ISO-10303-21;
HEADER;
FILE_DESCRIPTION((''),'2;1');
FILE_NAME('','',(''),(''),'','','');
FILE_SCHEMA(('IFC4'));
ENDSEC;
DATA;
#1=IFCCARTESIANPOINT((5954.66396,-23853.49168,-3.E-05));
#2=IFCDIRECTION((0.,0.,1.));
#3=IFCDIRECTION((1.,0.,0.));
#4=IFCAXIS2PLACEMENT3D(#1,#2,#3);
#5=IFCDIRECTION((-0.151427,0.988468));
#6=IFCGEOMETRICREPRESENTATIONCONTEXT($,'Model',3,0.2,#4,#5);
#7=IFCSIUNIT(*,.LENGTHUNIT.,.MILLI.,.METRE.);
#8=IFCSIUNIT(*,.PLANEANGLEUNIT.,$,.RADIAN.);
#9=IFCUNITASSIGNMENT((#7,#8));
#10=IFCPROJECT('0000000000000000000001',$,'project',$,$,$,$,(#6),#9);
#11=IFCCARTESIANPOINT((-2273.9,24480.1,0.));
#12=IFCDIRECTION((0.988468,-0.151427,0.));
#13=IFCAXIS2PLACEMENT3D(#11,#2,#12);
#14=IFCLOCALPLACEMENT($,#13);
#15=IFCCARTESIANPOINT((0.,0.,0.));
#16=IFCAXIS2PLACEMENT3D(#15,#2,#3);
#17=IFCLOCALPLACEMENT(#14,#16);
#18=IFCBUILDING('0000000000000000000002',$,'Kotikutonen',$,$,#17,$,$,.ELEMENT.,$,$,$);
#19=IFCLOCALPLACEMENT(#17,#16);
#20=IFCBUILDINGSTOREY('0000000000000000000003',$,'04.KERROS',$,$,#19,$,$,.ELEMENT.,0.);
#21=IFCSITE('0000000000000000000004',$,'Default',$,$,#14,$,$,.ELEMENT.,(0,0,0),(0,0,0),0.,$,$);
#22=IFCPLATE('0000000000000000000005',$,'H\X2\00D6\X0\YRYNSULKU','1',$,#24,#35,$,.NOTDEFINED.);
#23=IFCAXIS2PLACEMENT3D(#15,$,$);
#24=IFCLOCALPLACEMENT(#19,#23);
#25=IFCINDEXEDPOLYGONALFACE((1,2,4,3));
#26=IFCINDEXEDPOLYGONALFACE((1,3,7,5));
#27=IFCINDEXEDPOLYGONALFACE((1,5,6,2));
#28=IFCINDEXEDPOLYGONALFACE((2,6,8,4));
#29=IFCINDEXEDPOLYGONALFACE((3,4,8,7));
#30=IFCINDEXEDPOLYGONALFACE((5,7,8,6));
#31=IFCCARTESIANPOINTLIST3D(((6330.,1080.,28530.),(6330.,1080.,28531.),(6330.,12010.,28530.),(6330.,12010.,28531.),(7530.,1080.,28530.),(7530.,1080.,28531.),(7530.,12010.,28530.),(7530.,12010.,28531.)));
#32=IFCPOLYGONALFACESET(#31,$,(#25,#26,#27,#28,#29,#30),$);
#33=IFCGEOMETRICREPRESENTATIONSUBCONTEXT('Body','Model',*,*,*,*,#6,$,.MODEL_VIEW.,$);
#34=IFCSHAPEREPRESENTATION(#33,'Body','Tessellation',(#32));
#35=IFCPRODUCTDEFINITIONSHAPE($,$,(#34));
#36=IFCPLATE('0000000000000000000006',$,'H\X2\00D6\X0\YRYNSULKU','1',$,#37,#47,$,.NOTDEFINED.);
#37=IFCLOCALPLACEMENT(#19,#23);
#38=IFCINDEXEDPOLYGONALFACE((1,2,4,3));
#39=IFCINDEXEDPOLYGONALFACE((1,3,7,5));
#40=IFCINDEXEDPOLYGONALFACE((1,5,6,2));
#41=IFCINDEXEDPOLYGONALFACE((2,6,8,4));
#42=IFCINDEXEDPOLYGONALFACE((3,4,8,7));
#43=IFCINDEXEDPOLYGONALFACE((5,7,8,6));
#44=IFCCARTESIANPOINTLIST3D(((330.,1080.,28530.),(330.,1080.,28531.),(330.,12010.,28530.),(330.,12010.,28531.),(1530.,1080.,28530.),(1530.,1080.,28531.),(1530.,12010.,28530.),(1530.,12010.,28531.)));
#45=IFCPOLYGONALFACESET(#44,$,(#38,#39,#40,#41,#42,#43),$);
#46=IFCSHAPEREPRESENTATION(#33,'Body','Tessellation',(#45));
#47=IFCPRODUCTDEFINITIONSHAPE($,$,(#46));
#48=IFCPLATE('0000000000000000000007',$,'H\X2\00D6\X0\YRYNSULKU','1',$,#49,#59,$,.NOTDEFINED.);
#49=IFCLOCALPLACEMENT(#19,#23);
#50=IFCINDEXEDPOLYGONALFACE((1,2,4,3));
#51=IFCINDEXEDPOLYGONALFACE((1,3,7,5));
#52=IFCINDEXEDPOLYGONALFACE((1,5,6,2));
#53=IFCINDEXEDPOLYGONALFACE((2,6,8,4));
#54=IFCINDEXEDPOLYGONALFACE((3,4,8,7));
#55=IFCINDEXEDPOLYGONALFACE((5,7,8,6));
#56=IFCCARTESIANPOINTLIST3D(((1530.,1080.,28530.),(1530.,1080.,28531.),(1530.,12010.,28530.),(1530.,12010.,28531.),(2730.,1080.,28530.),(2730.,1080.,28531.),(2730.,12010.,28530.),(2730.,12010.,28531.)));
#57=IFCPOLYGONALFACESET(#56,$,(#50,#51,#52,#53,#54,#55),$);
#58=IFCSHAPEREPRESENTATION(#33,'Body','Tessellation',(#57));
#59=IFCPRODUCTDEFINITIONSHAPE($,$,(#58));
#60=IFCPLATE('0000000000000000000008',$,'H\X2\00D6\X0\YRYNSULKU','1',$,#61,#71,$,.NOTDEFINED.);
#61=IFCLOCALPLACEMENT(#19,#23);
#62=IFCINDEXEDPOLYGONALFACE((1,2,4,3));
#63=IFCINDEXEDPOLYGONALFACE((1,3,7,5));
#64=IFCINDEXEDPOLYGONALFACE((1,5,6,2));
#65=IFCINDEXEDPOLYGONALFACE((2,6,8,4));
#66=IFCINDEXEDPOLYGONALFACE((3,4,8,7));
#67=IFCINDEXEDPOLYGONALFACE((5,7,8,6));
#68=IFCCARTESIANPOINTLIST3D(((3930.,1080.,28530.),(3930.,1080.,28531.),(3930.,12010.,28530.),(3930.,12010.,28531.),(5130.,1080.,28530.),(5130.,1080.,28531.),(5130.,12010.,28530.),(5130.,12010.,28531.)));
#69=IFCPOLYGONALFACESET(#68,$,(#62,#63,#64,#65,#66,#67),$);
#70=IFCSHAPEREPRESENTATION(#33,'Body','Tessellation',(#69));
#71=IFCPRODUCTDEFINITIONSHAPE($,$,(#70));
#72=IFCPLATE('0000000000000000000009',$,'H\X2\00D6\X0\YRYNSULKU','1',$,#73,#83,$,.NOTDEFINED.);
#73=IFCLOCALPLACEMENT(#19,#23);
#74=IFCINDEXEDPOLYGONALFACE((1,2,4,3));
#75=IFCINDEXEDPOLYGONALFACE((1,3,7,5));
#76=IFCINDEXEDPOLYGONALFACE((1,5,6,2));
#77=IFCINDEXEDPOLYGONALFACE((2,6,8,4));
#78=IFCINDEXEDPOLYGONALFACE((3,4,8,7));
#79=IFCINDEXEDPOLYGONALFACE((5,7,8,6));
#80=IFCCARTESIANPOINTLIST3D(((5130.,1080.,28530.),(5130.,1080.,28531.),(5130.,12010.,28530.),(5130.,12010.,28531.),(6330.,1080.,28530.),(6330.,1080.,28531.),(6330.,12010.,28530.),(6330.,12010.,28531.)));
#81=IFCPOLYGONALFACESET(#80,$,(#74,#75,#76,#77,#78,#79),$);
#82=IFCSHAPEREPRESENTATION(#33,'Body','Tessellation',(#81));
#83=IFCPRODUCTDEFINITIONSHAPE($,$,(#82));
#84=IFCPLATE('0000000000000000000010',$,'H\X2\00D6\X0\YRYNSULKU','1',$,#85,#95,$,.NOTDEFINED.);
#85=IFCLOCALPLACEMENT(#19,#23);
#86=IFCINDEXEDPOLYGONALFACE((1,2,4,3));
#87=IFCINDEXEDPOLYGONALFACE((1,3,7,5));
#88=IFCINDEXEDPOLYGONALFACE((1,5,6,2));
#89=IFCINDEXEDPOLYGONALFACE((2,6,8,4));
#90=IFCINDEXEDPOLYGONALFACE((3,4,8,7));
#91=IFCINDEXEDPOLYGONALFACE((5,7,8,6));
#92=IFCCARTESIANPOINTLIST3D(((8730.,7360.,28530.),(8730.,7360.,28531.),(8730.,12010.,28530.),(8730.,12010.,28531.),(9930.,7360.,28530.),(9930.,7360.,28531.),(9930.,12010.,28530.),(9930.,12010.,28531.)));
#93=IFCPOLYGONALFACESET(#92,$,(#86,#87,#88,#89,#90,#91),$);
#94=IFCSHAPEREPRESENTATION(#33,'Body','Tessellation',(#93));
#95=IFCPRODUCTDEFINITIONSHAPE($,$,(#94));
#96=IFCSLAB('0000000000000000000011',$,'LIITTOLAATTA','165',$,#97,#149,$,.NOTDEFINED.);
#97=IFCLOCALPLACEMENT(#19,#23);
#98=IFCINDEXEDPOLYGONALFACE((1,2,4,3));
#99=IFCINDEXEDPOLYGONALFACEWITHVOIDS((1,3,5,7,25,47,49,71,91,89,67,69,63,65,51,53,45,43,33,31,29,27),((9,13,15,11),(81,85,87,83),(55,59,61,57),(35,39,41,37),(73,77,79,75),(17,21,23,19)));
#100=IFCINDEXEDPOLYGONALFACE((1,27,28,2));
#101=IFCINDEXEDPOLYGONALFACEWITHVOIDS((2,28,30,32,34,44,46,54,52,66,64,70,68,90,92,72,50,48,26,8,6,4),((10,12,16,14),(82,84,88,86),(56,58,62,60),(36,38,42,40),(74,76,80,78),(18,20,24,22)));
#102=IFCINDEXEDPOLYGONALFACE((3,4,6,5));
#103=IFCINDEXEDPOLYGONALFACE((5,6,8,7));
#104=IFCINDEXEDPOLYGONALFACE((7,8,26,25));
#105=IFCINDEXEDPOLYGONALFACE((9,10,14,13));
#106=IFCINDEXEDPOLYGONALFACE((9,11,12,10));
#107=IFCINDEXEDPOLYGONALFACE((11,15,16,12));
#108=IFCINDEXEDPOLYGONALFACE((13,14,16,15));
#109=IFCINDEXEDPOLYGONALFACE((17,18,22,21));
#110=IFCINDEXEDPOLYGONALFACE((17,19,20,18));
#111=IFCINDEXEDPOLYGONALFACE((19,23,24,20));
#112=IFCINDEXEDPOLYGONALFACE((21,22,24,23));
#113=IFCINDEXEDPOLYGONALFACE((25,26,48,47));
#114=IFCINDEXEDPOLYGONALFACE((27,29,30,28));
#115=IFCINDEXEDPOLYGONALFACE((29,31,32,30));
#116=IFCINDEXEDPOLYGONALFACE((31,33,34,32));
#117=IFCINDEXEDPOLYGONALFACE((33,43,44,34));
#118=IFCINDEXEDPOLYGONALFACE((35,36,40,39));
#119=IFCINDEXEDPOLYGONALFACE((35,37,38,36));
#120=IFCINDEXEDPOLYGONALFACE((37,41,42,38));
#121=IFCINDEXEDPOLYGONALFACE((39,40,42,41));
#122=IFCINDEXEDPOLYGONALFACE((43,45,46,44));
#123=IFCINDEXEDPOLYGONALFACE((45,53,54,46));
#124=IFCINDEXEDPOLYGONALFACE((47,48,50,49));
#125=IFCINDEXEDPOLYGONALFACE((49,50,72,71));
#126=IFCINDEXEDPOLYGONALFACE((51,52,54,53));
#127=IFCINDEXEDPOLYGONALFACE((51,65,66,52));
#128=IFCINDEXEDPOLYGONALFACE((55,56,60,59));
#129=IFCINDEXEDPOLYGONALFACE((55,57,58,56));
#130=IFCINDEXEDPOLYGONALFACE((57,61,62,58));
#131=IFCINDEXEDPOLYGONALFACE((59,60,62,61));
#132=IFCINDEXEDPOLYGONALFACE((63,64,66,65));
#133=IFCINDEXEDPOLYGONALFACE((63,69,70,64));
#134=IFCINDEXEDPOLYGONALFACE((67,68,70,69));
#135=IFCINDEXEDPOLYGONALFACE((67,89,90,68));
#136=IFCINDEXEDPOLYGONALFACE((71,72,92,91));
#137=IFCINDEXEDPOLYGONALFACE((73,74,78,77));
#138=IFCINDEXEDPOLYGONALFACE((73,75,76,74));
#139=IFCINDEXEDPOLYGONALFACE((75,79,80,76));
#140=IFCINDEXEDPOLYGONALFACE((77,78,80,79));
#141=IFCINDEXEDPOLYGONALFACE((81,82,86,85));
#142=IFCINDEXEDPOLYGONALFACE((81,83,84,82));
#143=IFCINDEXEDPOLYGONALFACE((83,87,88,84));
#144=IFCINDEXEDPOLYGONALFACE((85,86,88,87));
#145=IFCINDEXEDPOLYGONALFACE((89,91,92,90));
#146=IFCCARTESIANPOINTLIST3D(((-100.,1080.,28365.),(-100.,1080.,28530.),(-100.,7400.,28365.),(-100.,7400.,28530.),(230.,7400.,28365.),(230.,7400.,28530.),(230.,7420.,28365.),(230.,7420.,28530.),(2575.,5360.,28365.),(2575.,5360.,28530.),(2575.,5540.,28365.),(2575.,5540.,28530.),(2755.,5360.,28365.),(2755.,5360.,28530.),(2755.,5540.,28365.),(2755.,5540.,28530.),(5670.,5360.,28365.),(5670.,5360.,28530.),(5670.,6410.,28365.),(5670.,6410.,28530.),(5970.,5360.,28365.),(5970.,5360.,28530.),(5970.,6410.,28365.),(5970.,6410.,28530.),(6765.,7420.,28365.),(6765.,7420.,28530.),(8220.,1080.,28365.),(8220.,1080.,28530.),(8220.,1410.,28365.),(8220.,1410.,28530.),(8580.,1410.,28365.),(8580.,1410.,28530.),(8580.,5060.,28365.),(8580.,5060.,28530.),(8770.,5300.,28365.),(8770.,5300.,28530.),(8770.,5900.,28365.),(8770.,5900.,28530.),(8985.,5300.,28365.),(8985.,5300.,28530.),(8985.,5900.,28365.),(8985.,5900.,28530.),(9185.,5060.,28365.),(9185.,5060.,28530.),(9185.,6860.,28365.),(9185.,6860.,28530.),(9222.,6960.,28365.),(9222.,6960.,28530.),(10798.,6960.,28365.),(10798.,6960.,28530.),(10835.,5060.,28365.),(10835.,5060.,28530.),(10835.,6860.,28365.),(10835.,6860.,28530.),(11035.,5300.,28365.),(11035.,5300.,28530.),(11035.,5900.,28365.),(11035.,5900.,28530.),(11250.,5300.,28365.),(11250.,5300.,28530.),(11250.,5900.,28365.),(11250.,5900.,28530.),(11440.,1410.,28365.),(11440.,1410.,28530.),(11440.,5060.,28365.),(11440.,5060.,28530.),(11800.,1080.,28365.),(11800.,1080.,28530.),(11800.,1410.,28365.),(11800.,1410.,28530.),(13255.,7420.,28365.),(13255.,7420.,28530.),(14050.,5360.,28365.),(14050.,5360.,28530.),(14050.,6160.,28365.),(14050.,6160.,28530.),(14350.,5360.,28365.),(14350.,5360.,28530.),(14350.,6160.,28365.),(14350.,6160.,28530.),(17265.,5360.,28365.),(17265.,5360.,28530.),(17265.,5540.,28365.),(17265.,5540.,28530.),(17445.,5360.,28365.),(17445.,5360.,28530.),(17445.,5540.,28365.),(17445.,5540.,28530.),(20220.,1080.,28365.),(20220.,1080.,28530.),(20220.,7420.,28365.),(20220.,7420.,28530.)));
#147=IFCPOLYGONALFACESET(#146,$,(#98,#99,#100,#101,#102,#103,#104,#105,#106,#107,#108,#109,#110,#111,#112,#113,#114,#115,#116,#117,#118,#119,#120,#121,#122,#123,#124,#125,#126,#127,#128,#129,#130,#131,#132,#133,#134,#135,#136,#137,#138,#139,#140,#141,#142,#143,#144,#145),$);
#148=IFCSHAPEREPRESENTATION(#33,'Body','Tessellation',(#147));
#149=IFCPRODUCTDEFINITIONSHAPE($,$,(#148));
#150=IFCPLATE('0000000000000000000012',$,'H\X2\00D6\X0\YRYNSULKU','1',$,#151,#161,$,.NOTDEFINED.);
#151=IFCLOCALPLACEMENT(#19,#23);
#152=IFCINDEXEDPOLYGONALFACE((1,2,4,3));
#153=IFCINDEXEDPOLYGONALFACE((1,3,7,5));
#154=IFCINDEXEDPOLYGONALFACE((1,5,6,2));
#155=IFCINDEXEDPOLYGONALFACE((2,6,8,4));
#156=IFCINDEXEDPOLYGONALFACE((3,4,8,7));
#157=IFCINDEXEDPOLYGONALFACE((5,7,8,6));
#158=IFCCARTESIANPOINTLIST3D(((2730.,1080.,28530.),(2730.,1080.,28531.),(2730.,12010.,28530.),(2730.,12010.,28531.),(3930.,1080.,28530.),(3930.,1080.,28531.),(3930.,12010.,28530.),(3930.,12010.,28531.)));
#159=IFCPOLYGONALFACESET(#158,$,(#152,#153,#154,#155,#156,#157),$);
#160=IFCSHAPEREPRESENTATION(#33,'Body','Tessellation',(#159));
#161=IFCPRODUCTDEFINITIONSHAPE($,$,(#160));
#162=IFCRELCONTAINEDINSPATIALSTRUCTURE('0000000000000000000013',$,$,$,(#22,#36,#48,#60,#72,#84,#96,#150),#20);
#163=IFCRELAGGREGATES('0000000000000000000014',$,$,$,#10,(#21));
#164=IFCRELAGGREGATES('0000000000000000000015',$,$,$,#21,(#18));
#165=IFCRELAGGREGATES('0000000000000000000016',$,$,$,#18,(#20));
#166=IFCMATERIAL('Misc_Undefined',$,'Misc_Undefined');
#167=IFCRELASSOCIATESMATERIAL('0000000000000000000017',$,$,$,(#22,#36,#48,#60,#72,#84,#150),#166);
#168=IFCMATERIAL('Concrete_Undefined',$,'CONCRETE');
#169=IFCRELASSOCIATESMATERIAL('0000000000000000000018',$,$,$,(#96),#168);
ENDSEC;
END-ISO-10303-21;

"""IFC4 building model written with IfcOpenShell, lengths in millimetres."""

from ifc_helpers import new_model, si_unit, direction, frame, origin_with_axes, place, context, subcontext, project, spatial, line, indexed_curve, outline, extrude, material, element, save


model = new_model("IFC4")

# Units and contexts
model_context = context("Model", 3, precision=0.2, world=frame((5954.66396, -23853.49168, -3e-05), z_axis=(0.0, 0.0, 1.0), x_axis=(1.0, 0.0, 0.0)), true_north=direction((-0.151427, 0.988468)))
body_context = subcontext(model_context, "Body", "Model", "MODEL_VIEW")
ifc_project = project(units=[si_unit("LENGTHUNIT", "METRE", prefix="MILLI"), si_unit("PLANEANGLEUNIT", "RADIAN")], contexts=[model_context])

# Site, building, storey
site_placement = place(None, frame((-2273.9, 24480.1, 0.0), z_axis=(0.0, 0.0, 1.0), x_axis=(0.988468, -0.151427, 0.0)))
site = spatial("IfcSite", under=ifc_project, at=site_placement, Name="Default", CompositionType="ELEMENT", RefLatitude=(0, 0, 0), RefLongitude=(0, 0, 0), RefElevation=0.0)
building_placement = place(site_placement, origin_with_axes())
building = spatial("IfcBuilding", under=site, at=building_placement, Name="Kotikutonen", CompositionType="ELEMENT")
storey_placement = place(building_placement, origin_with_axes())
storey = spatial("IfcBuildingStorey", under=building, at=storey_placement, Name="04.KERROS", CompositionType="ELEMENT", Elevation=0.0)

# Shared definitions
ifc_material_1 = material(Name="Concrete_Undefined", Category="CONCRETE")

# Plates
ifc_material_2 = material(Name="Misc_Undefined", Category="Misc_Undefined")
for number, where, z_axis, x_axis, name in (
    (1, (6330.0, 1080.0, 28530.5), (0.0, 0.0, 1.0), (1.0, 0.0, 0.0), "HÖYRYNSULKU"),
    (2, (330.0, 1080.0, 28530.5), (0.0, 0.0, 1.0), (1.0, 0.0, 0.0), "HÖYRYNSULKU"),
    (3, (1530.0, 1080.0, 28530.5), (0.0, 0.0, 1.0), (1.0, 0.0, 0.0), "HÖYRYNSULKU"),
    (4, (3930.0, 1080.0, 28530.5), (0.0, 0.0, 1.0), (1.0, 0.0, 0.0), "HÖYRYNSULKU"),
    (5, (5130.0, 1080.0, 28530.5), (0.0, 0.0, 1.0), (1.0, 0.0, 0.0), "HÖYRYNSULKU"),
):
    element("IfcPlate", number, at=place(storey_placement, frame(where, z_axis=z_axis, x_axis=x_axis)), inside=storey, material=ifc_material_2, Name=name, Description="1", PredefinedType="NOTDEFINED", context=body_context, shape_type="SolidModel", body=[
        extrude(outline(indexed_curve([(0.0, 0.0), (1200.0, 0.0), (1200.0, 10930.0), (0.0, 10930.0)], segments=[line(1, 2, 3, 4, 1)])), frame((0.0, 0.0, 0.5), z_axis=(0.0, 0.0, 1.0), x_axis=(1.0, 0.0, 0.0)), (0.0, 0.0, -1.0), 1.0),
    ])
plate_1_placement = place(storey_placement, frame((8730.0, 7360.0, 28530.5), z_axis=(0.0, 0.0, 1.0), x_axis=(1.0, 0.0, 0.0)))
element("IfcPlate", 6, at=plate_1_placement, inside=storey, material=ifc_material_2, Name="HÖYRYNSULKU", Description="1", PredefinedType="NOTDEFINED", context=body_context, shape_type="SolidModel", body=[
    extrude(outline(indexed_curve([(0.0, 0.0), (1200.0, 0.0), (1200.0, 4650.0), (0.0, 4650.0)], segments=[line(1, 2, 3, 4, 1)])), frame((0.0, 0.0, 0.5), z_axis=(0.0, 0.0, 1.0), x_axis=(1.0, 0.0, 0.0)), (0.0, 0.0, -1.0), 1.0),
])

# Slab, voiding features
slab_1_placement = place(storey_placement, frame((-100.0, 7400.0, 28447.5), z_axis=(0.0, 0.0, 1.0), x_axis=(0.0, -1.0, 0.0)))
slab_1 = element("IfcSlab", 7, at=slab_1_placement, inside=storey, material=ifc_material_1, Name="LIITTOLAATTA", Description="165", PredefinedType="NOTDEFINED", context=body_context, shape_type="SolidModel", body=[
    extrude(outline(indexed_curve([(0.0, 0.0), (6320.0, 0.0), (6320.0, 8680.0), (7400.0, 8680.0), (7400.0, 11540.0), (6320.0, 11540.0), (6320.0, 20320.0), (-20.0, 20320.0), (-20.0, 13355.0), (440.0, 10898.0), (440.0, 9322.0), (-20.0, 6865.0), (-20.0, 330.0), (0.0, 330.0)], segments=[line(1, 2, 3, 4, 5, 6, 7, 8, 9, 10, 11, 12, 13, 14, 1)])), frame((0.0, 0.0, 82.5), z_axis=(0.0, 0.0, 1.0), x_axis=(1.0, 0.0, 0.0)), (0.0, 0.0, -1.0), 165.0),
])
voiding_feature_1_placement = place(slab_1_placement, frame((2340.0, 8680.0, 0.0), z_axis=(0.0, 0.0, 1.0), x_axis=(1.0, 0.0, 0.0)))
element("IfcVoidingFeature", 8, at=voiding_feature_1_placement, cuts=slab_1, Name="POLYGON CUT", PredefinedType="HOLE", context=body_context, shape_type="SolidModel", body=[
    extrude(outline(indexed_curve([(0.0, 0.0), (5060.0, 0.0), (5060.0, 2860.0), (0.0, 2860.0), (0.0, 2255.0), (-1800.0, 2255.0), (-1800.0, 605.0), (0.0, 605.0)], segments=[line(1, 2, 3, 4, 5, 6, 7, 8, 1)])), frame((0.0, 0.0, 157.5), z_axis=(0.0, 0.0, 1.0), x_axis=(1.0, 0.0, 0.0)), (0.0, 0.0, -1.0), 315.0),
])
voiding_feature_2_placement = place(slab_1_placement, frame((1500.0, 8870.0, 0.0), z_axis=(0.0, 0.0, 1.0), x_axis=(1.0, 0.0, 0.0)))
element("IfcVoidingFeature", 9, at=voiding_feature_2_placement, cuts=slab_1, Name="POLYGON CUT", PredefinedType="HOLE", context=body_context, shape_type="SolidModel", body=[
    extrude(outline(indexed_curve([(0.0, 0.0), (600.0, 0.0), (600.0, 215.0), (0.0, 215.0)], segments=[line(1, 2, 3, 4, 1)])), frame((0.0, 0.0, 157.5), z_axis=(0.0, 0.0, 1.0), x_axis=(1.0, 0.0, 0.0)), (0.0, 0.0, -1.0), 315.0),
])
voiding_feature_3_placement = place(slab_1_placement, frame((1500.0, 11135.0, 0.0), z_axis=(0.0, 0.0, 1.0), x_axis=(1.0, 0.0, 0.0)))
element("IfcVoidingFeature", 10, at=voiding_feature_3_placement, cuts=slab_1, Name="POLYGON CUT", PredefinedType="HOLE", context=body_context, shape_type="SolidModel", body=[
    extrude(outline(indexed_curve([(0.0, 0.0), (600.0, 0.0), (600.0, 215.0), (0.0, 215.0)], segments=[line(1, 2, 3, 4, 1)])), frame((0.0, 0.0, 157.5), z_axis=(0.0, 0.0, 1.0), x_axis=(1.0, 0.0, 0.0)), (0.0, 0.0, -1.0), 315.0),
])
voiding_feature_4_placement = place(slab_1_placement, frame((990.0, 5770.0, 0.0), z_axis=(0.0, 0.0, 1.0), x_axis=(1.0, 0.0, 0.0)))
element("IfcVoidingFeature", 11, at=voiding_feature_4_placement, cuts=slab_1, Name="POLYGON CUT", PredefinedType="HOLE", context=body_context, shape_type="SolidModel", body=[
    extrude(outline(indexed_curve([(0.0, 0.0), (1050.0, 0.0), (1050.0, 300.0), (0.0, 300.0)], segments=[line(1, 2, 3, 4, 1)])), frame((0.0, 0.0, 157.5), z_axis=(0.0, 0.0, 1.0), x_axis=(1.0, 0.0, 0.0)), (0.0, 0.0, -1.0), 315.0),
])
voiding_feature_5_placement = place(slab_1_placement, frame((1240.0, 14150.0, 0.0), z_axis=(0.0, 0.0, 1.0), x_axis=(1.0, 0.0, 0.0)))
element("IfcVoidingFeature", 12, at=voiding_feature_5_placement, cuts=slab_1, Name="POLYGON CUT", PredefinedType="HOLE", context=body_context, shape_type="SolidModel", body=[
    extrude(outline(indexed_curve([(0.0, 0.0), (800.0, 0.0), (800.0, 300.0), (0.0, 300.0)], segments=[line(1, 2, 3, 4, 1)])), frame((0.0, 0.0, 157.5), z_axis=(0.0, 0.0, 1.0), x_axis=(1.0, 0.0, 0.0)), (0.0, 0.0, -1.0), 315.0),
])
voiding_feature_6_placement = place(slab_1_placement, frame((1860.0, 2675.0, 0.0), z_axis=(0.0, 0.0, 1.0), x_axis=(1.0, 0.0, 0.0)))
element("IfcVoidingFeature", 13, at=voiding_feature_6_placement, cuts=slab_1, Name="POLYGON CUT", PredefinedType="HOLE", context=body_context, shape_type="SolidModel", body=[
    extrude(outline(indexed_curve([(0.0, 0.0), (180.0, 0.0), (180.0, 180.0), (0.0, 180.0)], segments=[line(1, 2, 3, 4, 1)])), frame((0.0, 0.0, 157.5), z_axis=(0.0, 0.0, 1.0), x_axis=(1.0, 0.0, 0.0)), (0.0, 0.0, -1.0), 315.0),
])
voiding_feature_7_placement = place(slab_1_placement, frame((1860.0, 17365.0, 0.0), z_axis=(0.0, 0.0, 1.0), x_axis=(1.0, 0.0, 0.0)))
element("IfcVoidingFeature", 14, at=voiding_feature_7_placement, cuts=slab_1, Name="POLYGON CUT", PredefinedType="HOLE", context=body_context, shape_type="SolidModel", body=[
    extrude(outline(indexed_curve([(0.0, 0.0), (180.0, 0.0), (180.0, 180.0), (0.0, 180.0)], segments=[line(1, 2, 3, 4, 1)])), frame((0.0, 0.0, 157.5), z_axis=(0.0, 0.0, 1.0), x_axis=(1.0, 0.0, 0.0)), (0.0, 0.0, -1.0), 315.0),
])
voiding_feature_8_placement = place(slab_1_placement, frame((5990.0, 11540.0, 0.0), z_axis=(0.0, 0.0, 1.0), x_axis=(1.0, 0.0, 0.0)))
element("IfcVoidingFeature", 15, at=voiding_feature_8_placement, cuts=slab_1, Name="POLYGON CUT", PredefinedType="HOLE", context=body_context, shape_type="SolidModel", body=[
    extrude(outline(indexed_curve([(0.0, 0.0), (330.0, 0.0), (330.0, 360.0), (0.0, 360.0)], segments=[line(1, 2, 3, 4, 1)])), frame((0.0, 0.0, 157.5), z_axis=(0.0, 0.0, 1.0), x_axis=(1.0, 0.0, 0.0)), (0.0, 0.0, -1.0), 315.0),
])
voiding_feature_9_placement = place(slab_1_placement, frame((6320.0, 8680.0, 0.0), z_axis=(0.0, 0.0, 1.0), x_axis=(-1.0, 0.0, 0.0)))
element("IfcVoidingFeature", 16, at=voiding_feature_9_placement, cuts=slab_1, Name="POLYGON CUT", PredefinedType="HOLE", context=body_context, shape_type="SolidModel", body=[
    extrude(outline(indexed_curve([(0.0, 0.0), (330.0, 0.0), (330.0, 360.0), (0.0, 360.0)], segments=[line(1, 2, 3, 4, 1)])), frame((0.0, 0.0, 157.5), z_axis=(0.0, 0.0, 1.0), x_axis=(1.0, 0.0, 0.0)), (0.0, 0.0, -1.0), 315.0),
])

# Plate
plate_2_placement = place(storey_placement, frame((2730.0, 1080.0, 28530.5), z_axis=(0.0, 0.0, 1.0), x_axis=(1.0, 0.0, 0.0)))
element("IfcPlate", 17, at=plate_2_placement, inside=storey, material=ifc_material_2, Name="HÖYRYNSULKU", Description="1", PredefinedType="NOTDEFINED", context=body_context, shape_type="SolidModel", body=[
    extrude(outline(indexed_curve([(0.0, 0.0), (1200.0, 0.0), (1200.0, 10930.0), (0.0, 10930.0)], segments=[line(1, 2, 3, 4, 1)])), frame((0.0, 0.0, 0.5), z_axis=(0.0, 0.0, 1.0), x_axis=(1.0, 0.0, 0.0)), (0.0, 0.0, -1.0), 1.0),
])

save(model, "model.ifc")
